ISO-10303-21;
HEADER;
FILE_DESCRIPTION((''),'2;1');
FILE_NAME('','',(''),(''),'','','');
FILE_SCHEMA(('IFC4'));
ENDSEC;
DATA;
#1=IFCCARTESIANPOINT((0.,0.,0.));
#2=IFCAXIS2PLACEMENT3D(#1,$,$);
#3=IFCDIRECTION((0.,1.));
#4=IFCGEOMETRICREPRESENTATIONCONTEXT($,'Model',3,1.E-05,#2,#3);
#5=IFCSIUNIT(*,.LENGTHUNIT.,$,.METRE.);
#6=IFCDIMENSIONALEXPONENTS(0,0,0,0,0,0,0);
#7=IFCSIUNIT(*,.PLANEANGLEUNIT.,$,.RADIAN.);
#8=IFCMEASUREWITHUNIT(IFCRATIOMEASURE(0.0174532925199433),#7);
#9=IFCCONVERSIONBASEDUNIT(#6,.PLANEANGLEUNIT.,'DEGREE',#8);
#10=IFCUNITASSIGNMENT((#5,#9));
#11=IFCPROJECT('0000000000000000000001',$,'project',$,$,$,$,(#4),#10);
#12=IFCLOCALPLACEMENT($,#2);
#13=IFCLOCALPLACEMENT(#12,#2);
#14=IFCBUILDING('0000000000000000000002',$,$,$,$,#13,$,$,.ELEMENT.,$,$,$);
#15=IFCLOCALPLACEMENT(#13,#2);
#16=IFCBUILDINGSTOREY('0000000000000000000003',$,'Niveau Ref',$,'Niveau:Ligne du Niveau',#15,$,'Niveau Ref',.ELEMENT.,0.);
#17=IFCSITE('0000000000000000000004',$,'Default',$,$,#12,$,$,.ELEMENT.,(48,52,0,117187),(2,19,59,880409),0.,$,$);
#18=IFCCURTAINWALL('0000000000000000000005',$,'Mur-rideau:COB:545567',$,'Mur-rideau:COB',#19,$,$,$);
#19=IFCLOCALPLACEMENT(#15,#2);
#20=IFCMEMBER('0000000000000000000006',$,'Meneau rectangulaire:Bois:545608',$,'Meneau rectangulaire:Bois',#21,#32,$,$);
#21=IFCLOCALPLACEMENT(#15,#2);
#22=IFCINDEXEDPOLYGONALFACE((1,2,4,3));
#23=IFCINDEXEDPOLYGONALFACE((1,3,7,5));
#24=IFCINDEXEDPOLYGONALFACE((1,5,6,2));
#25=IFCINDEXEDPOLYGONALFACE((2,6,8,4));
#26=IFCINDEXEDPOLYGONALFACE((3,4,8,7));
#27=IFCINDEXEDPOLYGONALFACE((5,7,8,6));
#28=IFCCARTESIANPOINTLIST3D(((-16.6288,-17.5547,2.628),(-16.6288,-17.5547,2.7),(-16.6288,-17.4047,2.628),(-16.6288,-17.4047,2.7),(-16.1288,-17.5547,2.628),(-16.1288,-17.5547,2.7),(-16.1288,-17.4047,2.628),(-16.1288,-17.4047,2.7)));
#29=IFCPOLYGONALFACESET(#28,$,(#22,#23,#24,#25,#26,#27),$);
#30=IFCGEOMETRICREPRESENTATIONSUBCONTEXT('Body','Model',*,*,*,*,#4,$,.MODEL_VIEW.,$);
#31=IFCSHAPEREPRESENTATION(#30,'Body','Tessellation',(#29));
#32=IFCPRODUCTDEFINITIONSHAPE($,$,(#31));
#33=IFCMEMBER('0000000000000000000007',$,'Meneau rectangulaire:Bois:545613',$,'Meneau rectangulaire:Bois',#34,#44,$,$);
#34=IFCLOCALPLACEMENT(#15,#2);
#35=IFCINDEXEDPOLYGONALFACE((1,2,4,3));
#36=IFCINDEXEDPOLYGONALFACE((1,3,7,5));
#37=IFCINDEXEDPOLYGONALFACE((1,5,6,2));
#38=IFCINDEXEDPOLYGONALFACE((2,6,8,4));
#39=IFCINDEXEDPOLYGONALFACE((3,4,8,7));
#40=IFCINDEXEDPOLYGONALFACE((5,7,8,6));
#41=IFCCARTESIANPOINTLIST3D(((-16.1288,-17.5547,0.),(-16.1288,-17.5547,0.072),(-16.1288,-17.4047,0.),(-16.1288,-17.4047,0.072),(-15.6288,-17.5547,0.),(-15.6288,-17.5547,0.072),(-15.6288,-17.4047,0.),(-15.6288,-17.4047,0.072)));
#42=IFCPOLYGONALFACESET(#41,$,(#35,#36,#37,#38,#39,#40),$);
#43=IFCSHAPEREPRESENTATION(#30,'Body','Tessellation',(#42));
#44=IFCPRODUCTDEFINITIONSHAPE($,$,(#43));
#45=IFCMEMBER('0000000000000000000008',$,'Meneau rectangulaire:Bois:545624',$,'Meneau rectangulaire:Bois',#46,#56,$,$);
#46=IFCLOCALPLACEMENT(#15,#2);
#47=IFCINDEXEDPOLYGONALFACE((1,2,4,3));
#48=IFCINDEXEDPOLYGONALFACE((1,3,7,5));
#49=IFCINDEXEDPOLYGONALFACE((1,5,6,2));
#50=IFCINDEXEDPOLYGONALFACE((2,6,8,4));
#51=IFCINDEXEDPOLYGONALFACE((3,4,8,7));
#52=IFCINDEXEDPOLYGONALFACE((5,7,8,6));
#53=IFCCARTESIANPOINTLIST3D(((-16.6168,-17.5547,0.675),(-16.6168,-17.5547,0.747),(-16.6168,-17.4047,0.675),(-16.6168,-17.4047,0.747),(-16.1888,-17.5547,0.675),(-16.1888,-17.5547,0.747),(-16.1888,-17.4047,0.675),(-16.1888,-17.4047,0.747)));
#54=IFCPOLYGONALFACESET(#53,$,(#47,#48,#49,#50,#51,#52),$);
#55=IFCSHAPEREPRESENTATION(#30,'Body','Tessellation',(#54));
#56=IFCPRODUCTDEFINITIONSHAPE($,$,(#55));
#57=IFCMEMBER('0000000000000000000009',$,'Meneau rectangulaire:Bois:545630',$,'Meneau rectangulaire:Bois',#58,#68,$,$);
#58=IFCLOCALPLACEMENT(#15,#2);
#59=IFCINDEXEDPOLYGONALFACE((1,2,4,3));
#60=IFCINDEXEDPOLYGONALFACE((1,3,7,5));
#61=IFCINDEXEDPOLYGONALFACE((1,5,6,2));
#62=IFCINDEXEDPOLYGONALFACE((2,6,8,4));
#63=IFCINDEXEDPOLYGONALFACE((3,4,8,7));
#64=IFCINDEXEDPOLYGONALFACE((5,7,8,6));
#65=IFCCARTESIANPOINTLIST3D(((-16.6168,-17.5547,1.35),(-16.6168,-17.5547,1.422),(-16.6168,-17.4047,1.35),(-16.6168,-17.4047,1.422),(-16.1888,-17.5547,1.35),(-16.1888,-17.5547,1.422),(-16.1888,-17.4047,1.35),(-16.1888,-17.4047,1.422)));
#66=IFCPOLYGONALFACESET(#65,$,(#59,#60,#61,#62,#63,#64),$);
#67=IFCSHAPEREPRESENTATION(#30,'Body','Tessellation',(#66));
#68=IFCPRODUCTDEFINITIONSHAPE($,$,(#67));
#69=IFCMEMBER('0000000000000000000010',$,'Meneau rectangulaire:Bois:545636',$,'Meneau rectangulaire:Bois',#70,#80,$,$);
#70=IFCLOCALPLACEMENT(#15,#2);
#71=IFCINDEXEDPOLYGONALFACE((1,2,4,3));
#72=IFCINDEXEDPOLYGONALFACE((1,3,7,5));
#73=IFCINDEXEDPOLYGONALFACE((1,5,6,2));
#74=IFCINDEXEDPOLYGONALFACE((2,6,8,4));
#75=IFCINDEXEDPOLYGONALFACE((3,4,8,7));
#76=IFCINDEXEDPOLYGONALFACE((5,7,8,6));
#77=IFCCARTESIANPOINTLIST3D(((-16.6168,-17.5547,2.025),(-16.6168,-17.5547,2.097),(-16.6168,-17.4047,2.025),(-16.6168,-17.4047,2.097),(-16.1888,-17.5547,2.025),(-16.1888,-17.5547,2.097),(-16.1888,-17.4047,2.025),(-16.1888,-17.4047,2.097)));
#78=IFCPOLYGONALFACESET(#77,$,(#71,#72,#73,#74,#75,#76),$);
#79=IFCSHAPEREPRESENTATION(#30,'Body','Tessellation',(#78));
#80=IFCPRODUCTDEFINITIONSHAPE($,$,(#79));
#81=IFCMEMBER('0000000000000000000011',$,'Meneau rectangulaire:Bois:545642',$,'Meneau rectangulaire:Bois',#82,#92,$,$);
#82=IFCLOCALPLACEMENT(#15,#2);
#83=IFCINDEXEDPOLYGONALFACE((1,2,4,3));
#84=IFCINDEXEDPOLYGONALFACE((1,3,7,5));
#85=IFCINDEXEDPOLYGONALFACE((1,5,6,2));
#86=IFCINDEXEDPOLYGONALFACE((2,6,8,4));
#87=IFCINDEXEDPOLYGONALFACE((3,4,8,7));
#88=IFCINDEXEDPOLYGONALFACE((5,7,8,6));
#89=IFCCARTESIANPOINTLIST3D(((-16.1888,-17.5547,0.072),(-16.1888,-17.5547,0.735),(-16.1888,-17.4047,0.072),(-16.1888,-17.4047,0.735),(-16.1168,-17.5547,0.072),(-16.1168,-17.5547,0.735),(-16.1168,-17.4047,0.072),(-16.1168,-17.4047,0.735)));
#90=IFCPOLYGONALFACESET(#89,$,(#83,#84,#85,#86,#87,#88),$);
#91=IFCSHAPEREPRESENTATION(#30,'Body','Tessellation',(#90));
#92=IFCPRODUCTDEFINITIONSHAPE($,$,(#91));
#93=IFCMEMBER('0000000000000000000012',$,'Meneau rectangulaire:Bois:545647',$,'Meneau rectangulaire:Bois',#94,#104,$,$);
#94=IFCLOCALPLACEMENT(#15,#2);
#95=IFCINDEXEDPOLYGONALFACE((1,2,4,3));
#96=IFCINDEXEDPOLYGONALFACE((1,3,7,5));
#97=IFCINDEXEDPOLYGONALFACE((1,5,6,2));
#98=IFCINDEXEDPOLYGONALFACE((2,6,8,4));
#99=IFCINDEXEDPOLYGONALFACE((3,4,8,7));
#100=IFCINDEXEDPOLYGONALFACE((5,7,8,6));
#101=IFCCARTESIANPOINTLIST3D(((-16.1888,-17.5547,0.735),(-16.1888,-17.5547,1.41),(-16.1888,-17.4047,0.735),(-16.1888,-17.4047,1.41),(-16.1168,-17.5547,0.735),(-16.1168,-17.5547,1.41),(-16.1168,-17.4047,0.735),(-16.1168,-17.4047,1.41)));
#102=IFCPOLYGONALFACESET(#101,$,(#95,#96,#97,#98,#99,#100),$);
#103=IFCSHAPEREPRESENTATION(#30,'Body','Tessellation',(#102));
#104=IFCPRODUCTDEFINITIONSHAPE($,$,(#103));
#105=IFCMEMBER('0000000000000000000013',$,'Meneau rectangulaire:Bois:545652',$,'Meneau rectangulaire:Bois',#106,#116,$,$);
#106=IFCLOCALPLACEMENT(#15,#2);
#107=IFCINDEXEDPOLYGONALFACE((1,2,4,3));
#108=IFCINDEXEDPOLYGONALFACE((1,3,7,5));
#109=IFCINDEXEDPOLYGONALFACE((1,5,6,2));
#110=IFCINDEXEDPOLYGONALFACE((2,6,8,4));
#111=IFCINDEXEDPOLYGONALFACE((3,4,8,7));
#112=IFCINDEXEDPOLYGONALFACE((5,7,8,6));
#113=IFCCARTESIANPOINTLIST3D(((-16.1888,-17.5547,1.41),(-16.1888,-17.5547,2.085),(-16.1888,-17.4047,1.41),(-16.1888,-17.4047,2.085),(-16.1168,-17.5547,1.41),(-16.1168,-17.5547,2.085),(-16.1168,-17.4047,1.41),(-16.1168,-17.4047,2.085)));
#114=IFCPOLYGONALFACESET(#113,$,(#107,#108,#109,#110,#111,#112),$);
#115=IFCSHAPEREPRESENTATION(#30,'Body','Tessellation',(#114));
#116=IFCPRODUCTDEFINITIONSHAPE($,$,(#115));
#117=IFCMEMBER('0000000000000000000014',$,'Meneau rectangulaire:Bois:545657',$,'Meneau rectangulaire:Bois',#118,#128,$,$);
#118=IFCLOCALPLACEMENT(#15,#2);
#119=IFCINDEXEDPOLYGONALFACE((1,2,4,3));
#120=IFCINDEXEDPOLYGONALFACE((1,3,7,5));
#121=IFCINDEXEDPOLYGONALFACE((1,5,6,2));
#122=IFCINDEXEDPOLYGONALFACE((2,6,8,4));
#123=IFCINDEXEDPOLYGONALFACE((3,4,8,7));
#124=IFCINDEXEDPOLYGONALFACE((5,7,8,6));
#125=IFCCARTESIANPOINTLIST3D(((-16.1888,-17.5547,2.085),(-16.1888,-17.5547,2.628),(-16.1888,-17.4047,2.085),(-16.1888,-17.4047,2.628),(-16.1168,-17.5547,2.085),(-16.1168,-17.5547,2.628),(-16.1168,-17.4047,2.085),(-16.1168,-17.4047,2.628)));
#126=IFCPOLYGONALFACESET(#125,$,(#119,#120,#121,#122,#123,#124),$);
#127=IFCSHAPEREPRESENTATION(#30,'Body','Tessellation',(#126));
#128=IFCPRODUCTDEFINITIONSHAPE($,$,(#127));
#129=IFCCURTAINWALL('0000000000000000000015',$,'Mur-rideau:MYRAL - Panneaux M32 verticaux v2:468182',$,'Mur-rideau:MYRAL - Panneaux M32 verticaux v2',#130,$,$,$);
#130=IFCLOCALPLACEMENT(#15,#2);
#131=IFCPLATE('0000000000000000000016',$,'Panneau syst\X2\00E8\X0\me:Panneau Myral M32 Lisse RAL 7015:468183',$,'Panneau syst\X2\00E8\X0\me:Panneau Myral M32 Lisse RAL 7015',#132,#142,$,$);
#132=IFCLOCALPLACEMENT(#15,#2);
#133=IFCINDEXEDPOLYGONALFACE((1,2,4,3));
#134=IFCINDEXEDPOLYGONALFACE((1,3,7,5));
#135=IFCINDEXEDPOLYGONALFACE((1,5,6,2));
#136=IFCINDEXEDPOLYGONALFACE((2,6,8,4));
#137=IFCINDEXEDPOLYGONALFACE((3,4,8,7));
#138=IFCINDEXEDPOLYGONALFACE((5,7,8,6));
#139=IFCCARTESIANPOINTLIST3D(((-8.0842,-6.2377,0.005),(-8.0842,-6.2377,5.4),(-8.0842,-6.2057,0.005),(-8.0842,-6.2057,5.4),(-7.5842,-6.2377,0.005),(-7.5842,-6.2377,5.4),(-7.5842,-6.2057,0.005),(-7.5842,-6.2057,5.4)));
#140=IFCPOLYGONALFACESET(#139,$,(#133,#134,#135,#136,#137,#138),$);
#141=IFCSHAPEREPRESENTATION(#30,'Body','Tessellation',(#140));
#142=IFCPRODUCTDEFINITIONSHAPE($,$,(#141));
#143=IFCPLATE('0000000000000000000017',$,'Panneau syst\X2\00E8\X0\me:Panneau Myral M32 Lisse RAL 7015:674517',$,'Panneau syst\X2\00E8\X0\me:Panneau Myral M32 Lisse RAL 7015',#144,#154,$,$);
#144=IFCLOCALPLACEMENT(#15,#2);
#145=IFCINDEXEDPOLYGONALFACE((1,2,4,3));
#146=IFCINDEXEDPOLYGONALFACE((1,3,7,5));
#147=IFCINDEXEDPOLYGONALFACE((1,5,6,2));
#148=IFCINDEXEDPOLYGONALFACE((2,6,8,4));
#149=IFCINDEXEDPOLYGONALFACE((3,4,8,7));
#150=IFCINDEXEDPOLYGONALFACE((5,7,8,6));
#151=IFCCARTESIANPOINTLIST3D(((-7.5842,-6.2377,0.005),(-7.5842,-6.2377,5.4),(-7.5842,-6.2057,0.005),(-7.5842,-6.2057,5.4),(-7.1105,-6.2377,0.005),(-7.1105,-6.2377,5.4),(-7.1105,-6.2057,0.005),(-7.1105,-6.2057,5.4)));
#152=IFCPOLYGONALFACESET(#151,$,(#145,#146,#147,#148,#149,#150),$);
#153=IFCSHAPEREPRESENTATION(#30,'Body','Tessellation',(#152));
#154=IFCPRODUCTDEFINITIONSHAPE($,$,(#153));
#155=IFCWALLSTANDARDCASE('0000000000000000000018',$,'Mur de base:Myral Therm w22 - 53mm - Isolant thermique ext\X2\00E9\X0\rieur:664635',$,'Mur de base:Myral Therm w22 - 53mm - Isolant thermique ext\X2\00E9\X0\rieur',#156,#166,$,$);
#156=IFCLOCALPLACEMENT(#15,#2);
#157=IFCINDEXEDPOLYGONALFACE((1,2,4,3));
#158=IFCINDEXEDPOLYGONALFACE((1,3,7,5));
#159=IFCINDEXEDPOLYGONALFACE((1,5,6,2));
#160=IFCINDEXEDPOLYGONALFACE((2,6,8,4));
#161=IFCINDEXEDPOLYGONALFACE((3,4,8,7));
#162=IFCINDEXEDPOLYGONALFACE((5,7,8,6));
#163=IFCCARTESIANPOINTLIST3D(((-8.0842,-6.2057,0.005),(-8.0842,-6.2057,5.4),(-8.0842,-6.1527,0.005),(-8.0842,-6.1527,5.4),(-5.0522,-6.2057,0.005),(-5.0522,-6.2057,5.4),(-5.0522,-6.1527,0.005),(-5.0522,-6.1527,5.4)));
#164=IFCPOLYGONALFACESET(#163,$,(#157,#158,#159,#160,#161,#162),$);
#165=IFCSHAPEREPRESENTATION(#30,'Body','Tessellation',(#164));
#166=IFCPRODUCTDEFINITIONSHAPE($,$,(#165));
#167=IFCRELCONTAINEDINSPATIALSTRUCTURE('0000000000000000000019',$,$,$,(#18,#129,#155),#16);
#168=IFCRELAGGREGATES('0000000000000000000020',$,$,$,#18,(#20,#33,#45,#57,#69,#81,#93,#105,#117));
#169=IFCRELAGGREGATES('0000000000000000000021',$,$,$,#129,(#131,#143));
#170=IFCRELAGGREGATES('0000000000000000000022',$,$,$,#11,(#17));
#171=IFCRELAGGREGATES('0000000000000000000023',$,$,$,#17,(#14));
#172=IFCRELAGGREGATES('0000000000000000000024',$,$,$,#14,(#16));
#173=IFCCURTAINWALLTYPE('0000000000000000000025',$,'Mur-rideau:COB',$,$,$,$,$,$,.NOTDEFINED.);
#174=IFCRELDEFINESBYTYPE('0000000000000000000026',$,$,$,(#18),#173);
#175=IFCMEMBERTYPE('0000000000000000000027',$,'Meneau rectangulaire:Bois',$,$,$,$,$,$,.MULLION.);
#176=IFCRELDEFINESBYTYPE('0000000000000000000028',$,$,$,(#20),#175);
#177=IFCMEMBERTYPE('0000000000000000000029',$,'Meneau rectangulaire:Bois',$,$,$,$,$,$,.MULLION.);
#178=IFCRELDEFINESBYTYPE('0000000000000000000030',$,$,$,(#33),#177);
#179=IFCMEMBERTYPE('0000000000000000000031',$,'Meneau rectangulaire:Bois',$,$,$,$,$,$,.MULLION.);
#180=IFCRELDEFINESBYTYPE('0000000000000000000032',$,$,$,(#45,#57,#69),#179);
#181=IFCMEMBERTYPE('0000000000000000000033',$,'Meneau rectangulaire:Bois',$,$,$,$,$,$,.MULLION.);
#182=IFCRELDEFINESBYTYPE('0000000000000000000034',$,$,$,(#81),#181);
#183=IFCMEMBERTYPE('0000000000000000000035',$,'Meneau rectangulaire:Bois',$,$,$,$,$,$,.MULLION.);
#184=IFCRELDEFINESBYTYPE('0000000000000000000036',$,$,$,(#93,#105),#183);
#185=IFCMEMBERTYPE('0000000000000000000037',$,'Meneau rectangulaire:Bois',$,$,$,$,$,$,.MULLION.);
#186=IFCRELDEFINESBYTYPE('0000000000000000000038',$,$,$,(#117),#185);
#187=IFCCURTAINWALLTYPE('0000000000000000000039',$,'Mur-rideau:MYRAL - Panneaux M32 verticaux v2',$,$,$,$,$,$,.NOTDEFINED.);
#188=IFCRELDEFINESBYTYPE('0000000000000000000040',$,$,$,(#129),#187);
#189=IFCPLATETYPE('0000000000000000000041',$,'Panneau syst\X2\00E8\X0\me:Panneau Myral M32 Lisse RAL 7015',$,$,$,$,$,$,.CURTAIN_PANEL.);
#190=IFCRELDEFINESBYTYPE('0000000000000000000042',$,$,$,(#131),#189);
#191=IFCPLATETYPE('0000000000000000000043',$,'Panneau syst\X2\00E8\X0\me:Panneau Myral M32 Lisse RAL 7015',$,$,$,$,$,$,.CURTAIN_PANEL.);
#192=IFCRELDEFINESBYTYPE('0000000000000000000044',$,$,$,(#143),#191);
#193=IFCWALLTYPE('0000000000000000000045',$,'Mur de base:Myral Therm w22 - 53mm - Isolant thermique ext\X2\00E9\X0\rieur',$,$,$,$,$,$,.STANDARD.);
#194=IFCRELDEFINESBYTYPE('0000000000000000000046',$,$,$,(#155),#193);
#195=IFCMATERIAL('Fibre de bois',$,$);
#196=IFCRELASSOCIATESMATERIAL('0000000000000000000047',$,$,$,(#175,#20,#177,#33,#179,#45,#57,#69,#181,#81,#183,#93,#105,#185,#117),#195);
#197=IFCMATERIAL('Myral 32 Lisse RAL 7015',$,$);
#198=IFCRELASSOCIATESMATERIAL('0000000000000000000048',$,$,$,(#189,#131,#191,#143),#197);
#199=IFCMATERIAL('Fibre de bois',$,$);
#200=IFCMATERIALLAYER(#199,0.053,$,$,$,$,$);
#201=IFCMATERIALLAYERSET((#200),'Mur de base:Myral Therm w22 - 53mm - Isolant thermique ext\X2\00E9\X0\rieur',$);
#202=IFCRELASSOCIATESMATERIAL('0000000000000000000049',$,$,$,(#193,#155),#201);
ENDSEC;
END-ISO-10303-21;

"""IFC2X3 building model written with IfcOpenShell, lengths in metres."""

from ifc_helpers import new_model, entity, si_unit, converted_unit, direction, frame, frame_2d, origin, origin_2d_with_axis, place, context, subcontext, project, spatial, rectangle, extrude, source, transform, mapped, material, layer, layer_set, layer_usage, type_object, type_shapes, element, aggregate, save


model = new_model("IFC2X3")

# Units and contexts
model_context = context("Model", 3, precision=1e-05, world=origin(), true_north=direction((0.0, 1.0)))
body_context = subcontext(model_context, "Body", "Model", "MODEL_VIEW")
ifc_project = project(units=[si_unit("LENGTHUNIT", "METRE"), converted_unit("PLANEANGLEUNIT", "DEGREE", entity("IfcRatioMeasure", 0.0174532925199433), si_unit("PLANEANGLEUNIT", "RADIAN"), dimensions=[0, 0, 0, 0, 0, 0, 0])], contexts=[model_context])

# Site, building, storey
site_placement = place(None, origin())
site = spatial("IfcSite", under=ifc_project, at=site_placement, Name="Default", CompositionType="ELEMENT", RefLatitude=(48, 52, 0, 117187), RefLongitude=(2, 19, 59, 880409), RefElevation=0.0)
building_placement = place(site_placement, origin())
building = spatial("IfcBuilding", under=site, at=building_placement, CompositionType="ELEMENT")
storey_placement = place(building_placement, origin())
storey = spatial("IfcBuildingStorey", under=building, at=storey_placement, Name="Niveau Ref", ObjectType="Niveau:Ligne du Niveau", LongName="Niveau Ref", CompositionType="ELEMENT", Elevation=0.0)

# Curtain wall, members
curtain_wall_type_1 = type_object("IfcCurtainWallType", Name="Mur-rideau:COB", PredefinedType="NOTDEFINED")
curtain_wall_1_placement = place(storey_placement, origin())
curtain_wall_1 = element("IfcCurtainWall", 1, at=curtain_wall_1_placement, inside=storey, type_object=curtain_wall_type_1, Name="Mur-rideau:COB:545567", ObjectType="Mur-rideau:COB")
ifc_material_1 = material(Name="Fibre de bois")
member_type_1 = type_object("IfcMemberType", Name="Meneau rectangulaire:Bois", PredefinedType="MULLION", material=ifc_material_1)
shared_shape_1 = source(origin(), body_context, "Body", "SweptSolid", [
    extrude(rectangle(XDim=0.15, YDim=0.072, at=origin_2d_with_axis()), frame((-0.036, 0.0, -0.5), z_axis=(0.0, 0.0, 1.0), x_axis=(0.0, -1.0, 0.0)), (0.0, 0.0, 1.0), 0.5),
])
type_shapes(member_type_1, [shared_shape_1])
member_1_placement = place(storey_placement, frame((-16.1288, -17.4797, 2.7), z_axis=(1.0, 0.0, 0.0), x_axis=(0.0, 0.0, 1.0)))
member_1 = element("IfcMember", 2, at=member_1_placement, type_object=member_type_1, material=ifc_material_1, Name="Meneau rectangulaire:Bois:545608", ObjectType="Meneau rectangulaire:Bois", context=body_context, shape_type="MappedRepresentation", body=[
    mapped(shared_shape_1, transform((0.0, 0.0, 0.0), scale=1.0)),
])
member_type_2 = type_object("IfcMemberType", Name="Meneau rectangulaire:Bois", PredefinedType="MULLION", material=ifc_material_1)
shared_shape_2 = source(origin(), body_context, "Body", "SweptSolid", [
    extrude(rectangle(XDim=0.15, YDim=0.072, at=origin_2d_with_axis()), frame((-0.036, 0.0, -0.5), z_axis=(0.0, 0.0, 1.0), x_axis=(0.0, -1.0, 0.0)), (0.0, 0.0, 1.0), 0.5),
])
type_shapes(member_type_2, [shared_shape_2])
member_2_placement = place(storey_placement, frame((-16.1288, -17.4797, 0.0), z_axis=(-1.0, 0.0, 0.0), x_axis=(0.0, 0.0, -1.0)))
member_2 = element("IfcMember", 3, at=member_2_placement, type_object=member_type_2, material=ifc_material_1, Name="Meneau rectangulaire:Bois:545613", ObjectType="Meneau rectangulaire:Bois", context=body_context, shape_type="MappedRepresentation", body=[
    mapped(shared_shape_2, transform((0.0, 0.0, 0.0), scale=1.0)),
])
member_type_3 = type_object("IfcMemberType", Name="Meneau rectangulaire:Bois", PredefinedType="MULLION", material=ifc_material_1)
shared_shape_3 = source(origin(), body_context, "Body", "SweptSolid", [
    extrude(rectangle(XDim=0.15, YDim=0.072, at=origin_2d_with_axis()), frame((-0.024, 0.0, -0.428), z_axis=(0.0, 0.0, 1.0), x_axis=(0.0, -1.0, 0.0)), (0.0, 0.0, 1.0), 0.428),
])
type_shapes(member_type_3, [shared_shape_3])
member_3_placement = place(storey_placement, frame((-16.1888, -17.4797, 0.735), z_axis=(1.0, 0.0, 0.0), x_axis=(0.0, 0.0, 1.0)))
member_3 = element("IfcMember", 4, at=member_3_placement, type_object=member_type_3, material=ifc_material_1, Name="Meneau rectangulaire:Bois:545624", ObjectType="Meneau rectangulaire:Bois", context=body_context, shape_type="MappedRepresentation", body=[
    mapped(shared_shape_3, transform((0.0, 0.0, 0.0), scale=1.0)),
])
member_4_placement = place(storey_placement, frame((-16.1888, -17.4797, 1.41), z_axis=(1.0, 0.0, 0.0), x_axis=(0.0, 0.0, 1.0)))
member_4 = element("IfcMember", 5, at=member_4_placement, type_object=member_type_3, material=ifc_material_1, Name="Meneau rectangulaire:Bois:545630", ObjectType="Meneau rectangulaire:Bois", context=body_context, shape_type="MappedRepresentation", body=[
    mapped(shared_shape_3, transform((0.0, 0.0, 0.0), scale=1.0)),
])
member_5_placement = place(storey_placement, frame((-16.1888, -17.4797, 2.085), z_axis=(1.0, 0.0, 0.0), x_axis=(0.0, 0.0, 1.0)))
member_5 = element("IfcMember", 6, at=member_5_placement, type_object=member_type_3, material=ifc_material_1, Name="Meneau rectangulaire:Bois:545636", ObjectType="Meneau rectangulaire:Bois", context=body_context, shape_type="MappedRepresentation", body=[
    mapped(shared_shape_3, transform((0.0, 0.0, 0.0), scale=1.0)),
])
member_type_4 = type_object("IfcMemberType", Name="Meneau rectangulaire:Bois", PredefinedType="MULLION", material=ifc_material_1)
shared_shape_4 = source(origin(), body_context, "Body", "SweptSolid", [
    extrude(rectangle(XDim=0.15, YDim=0.072, at=origin_2d_with_axis()), frame((-0.024, 0.0, -0.663), z_axis=(0.0, 0.0, 1.0), x_axis=(0.0, -1.0, 0.0)), (0.0, 0.0, 1.0), 0.663),
])
type_shapes(member_type_4, [shared_shape_4])
member_6_placement = place(storey_placement, frame((-16.1288, -17.4797, 0.072), z_axis=(0.0, 0.0, -1.0), x_axis=(1.0, 0.0, 0.0)))
member_6 = element("IfcMember", 7, at=member_6_placement, type_object=member_type_4, material=ifc_material_1, Name="Meneau rectangulaire:Bois:545642", ObjectType="Meneau rectangulaire:Bois", context=body_context, shape_type="MappedRepresentation", body=[
    mapped(shared_shape_4, transform((0.0, 0.0, 0.0), scale=1.0)),
])
member_type_5 = type_object("IfcMemberType", Name="Meneau rectangulaire:Bois", PredefinedType="MULLION", material=ifc_material_1)
shared_shape_5 = source(origin(), body_context, "Body", "SweptSolid", [
    extrude(rectangle(XDim=0.15, YDim=0.072, at=origin_2d_with_axis()), frame((-0.024, 0.0, -0.675), z_axis=(0.0, 0.0, 1.0), x_axis=(0.0, -1.0, 0.0)), (0.0, 0.0, 1.0), 0.675),
])
type_shapes(member_type_5, [shared_shape_5])
member_7_placement = place(storey_placement, frame((-16.1288, -17.4797, 0.735), z_axis=(0.0, 0.0, -1.0), x_axis=(1.0, 0.0, 0.0)))
member_7 = element("IfcMember", 8, at=member_7_placement, type_object=member_type_5, material=ifc_material_1, Name="Meneau rectangulaire:Bois:545647", ObjectType="Meneau rectangulaire:Bois", context=body_context, shape_type="MappedRepresentation", body=[
    mapped(shared_shape_5, transform((0.0, 0.0, 0.0), scale=1.0)),
])
member_8_placement = place(storey_placement, frame((-16.1288, -17.4797, 1.41), z_axis=(0.0, 0.0, -1.0), x_axis=(1.0, 0.0, 0.0)))
member_8 = element("IfcMember", 9, at=member_8_placement, type_object=member_type_5, material=ifc_material_1, Name="Meneau rectangulaire:Bois:545652", ObjectType="Meneau rectangulaire:Bois", context=body_context, shape_type="MappedRepresentation", body=[
    mapped(shared_shape_5, transform((0.0, 0.0, 0.0), scale=1.0)),
])
member_type_6 = type_object("IfcMemberType", Name="Meneau rectangulaire:Bois", PredefinedType="MULLION", material=ifc_material_1)
shared_shape_6 = source(origin(), body_context, "Body", "SweptSolid", [
    extrude(rectangle(XDim=0.15, YDim=0.072, at=origin_2d_with_axis()), frame((-0.024, 0.0, -0.543), z_axis=(0.0, 0.0, 1.0), x_axis=(0.0, -1.0, 0.0)), (0.0, 0.0, 1.0), 0.543),
])
type_shapes(member_type_6, [shared_shape_6])
member_9_placement = place(storey_placement, frame((-16.1288, -17.4797, 2.085), z_axis=(0.0, 0.0, -1.0), x_axis=(1.0, 0.0, 0.0)))
member_9 = element("IfcMember", 10, at=member_9_placement, type_object=member_type_6, material=ifc_material_1, Name="Meneau rectangulaire:Bois:545657", ObjectType="Meneau rectangulaire:Bois", context=body_context, shape_type="MappedRepresentation", body=[
    mapped(shared_shape_6, transform((0.0, 0.0, 0.0), scale=1.0)),
])
aggregate(curtain_wall_1, [member_1, member_2, member_3, member_4, member_5, member_6, member_7, member_8, member_9])

# Curtain wall, plates
curtain_wall_type_2 = type_object("IfcCurtainWallType", Name="Mur-rideau:MYRAL - Panneaux M32 verticaux v2", PredefinedType="NOTDEFINED")
curtain_wall_2_placement = place(storey_placement, origin())
curtain_wall_2 = element("IfcCurtainWall", 11, at=curtain_wall_2_placement, inside=storey, type_object=curtain_wall_type_2, Name="Mur-rideau:MYRAL - Panneaux M32 verticaux v2:468182", ObjectType="Mur-rideau:MYRAL - Panneaux M32 verticaux v2")
ifc_material_2 = material(Name="Myral 32 Lisse RAL 7015")
plate_type_1 = type_object("IfcPlateType", Name="Panneau système:Panneau Myral M32 Lisse RAL 7015", PredefinedType="CURTAIN_PANEL", material=ifc_material_2)
shared_shape_7 = source(origin(), body_context, "Body", "SweptSolid", [
    extrude(rectangle(XDim=0.032, YDim=0.5, at=origin_2d_with_axis()), frame((0.0, -0.016, 0.0), z_axis=(0.0, 0.0, 1.0), x_axis=(0.0, 1.0, 0.0)), (0.0, 0.0, 1.0), 5.395),
])
type_shapes(plate_type_1, [shared_shape_7])
plate_1_placement = place(curtain_wall_2_placement, frame((-7.8342, -6.2057, 0.005)))
plate_1 = element("IfcPlate", 12, at=plate_1_placement, type_object=plate_type_1, material=ifc_material_2, Name="Panneau système:Panneau Myral M32 Lisse RAL 7015:468183", ObjectType="Panneau système:Panneau Myral M32 Lisse RAL 7015", context=body_context, shape_type="MappedRepresentation", body=[
    mapped(shared_shape_7, transform((0.0, 0.0, 0.0), scale=1.0)),
])
plate_type_2 = type_object("IfcPlateType", Name="Panneau système:Panneau Myral M32 Lisse RAL 7015", PredefinedType="CURTAIN_PANEL", material=ifc_material_2)
shared_shape_8 = source(origin(), body_context, "Body", "SweptSolid", [
    extrude(rectangle(XDim=0.032, YDim=0.4737, at=origin_2d_with_axis()), frame((0.0, -0.016, 0.0), z_axis=(0.0, 0.0, 1.0), x_axis=(0.0, 1.0, 0.0)), (0.0, 0.0, 1.0), 5.395),
])
type_shapes(plate_type_2, [shared_shape_8])
plate_2_placement = place(curtain_wall_2_placement, frame((-7.3474, -6.2057, 0.005)))
plate_2 = element("IfcPlate", 13, at=plate_2_placement, type_object=plate_type_2, material=ifc_material_2, Name="Panneau système:Panneau Myral M32 Lisse RAL 7015:674517", ObjectType="Panneau système:Panneau Myral M32 Lisse RAL 7015", context=body_context, shape_type="MappedRepresentation", body=[
    mapped(shared_shape_8, transform((0.0, 0.0, 0.0), scale=1.0)),
])
aggregate(curtain_wall_2, [plate_1, plate_2])

# Wall
ifc_material_3 = material(Name="Fibre de bois")
ifc_layer = layer(ifc_material_3, 0.053)
ifc_layer_set = layer_set([ifc_layer], Name="Mur de base:Myral Therm w22 - 53mm - Isolant thermique extérieur")
ifc_layer_usage = layer_usage(ifc_layer_set, "AXIS2", "NEGATIVE", 0.0265)
wall_type = type_object("IfcWallType", Name="Mur de base:Myral Therm w22 - 53mm - Isolant thermique extérieur", PredefinedType="STANDARD", material=ifc_layer_set)
wall_placement = place(storey_placement, frame((-8.0842, -6.1792, 0.005)))
element("IfcWallStandardCase", 14, at=wall_placement, inside=storey, type_object=wall_type, material=ifc_layer_usage, Name="Mur de base:Myral Therm w22 - 53mm - Isolant thermique extérieur:664635", ObjectType="Mur de base:Myral Therm w22 - 53mm - Isolant thermique extérieur", context=body_context, shape_type="SweptSolid", body=[
    extrude(rectangle(XDim=3.032, YDim=0.053, at=frame_2d((1.516, 0.0), x_axis=(-1.0, 0.0))), origin(), (0.0, 0.0, 1.0), 5.395),
])

save(model, "model.ifc")
